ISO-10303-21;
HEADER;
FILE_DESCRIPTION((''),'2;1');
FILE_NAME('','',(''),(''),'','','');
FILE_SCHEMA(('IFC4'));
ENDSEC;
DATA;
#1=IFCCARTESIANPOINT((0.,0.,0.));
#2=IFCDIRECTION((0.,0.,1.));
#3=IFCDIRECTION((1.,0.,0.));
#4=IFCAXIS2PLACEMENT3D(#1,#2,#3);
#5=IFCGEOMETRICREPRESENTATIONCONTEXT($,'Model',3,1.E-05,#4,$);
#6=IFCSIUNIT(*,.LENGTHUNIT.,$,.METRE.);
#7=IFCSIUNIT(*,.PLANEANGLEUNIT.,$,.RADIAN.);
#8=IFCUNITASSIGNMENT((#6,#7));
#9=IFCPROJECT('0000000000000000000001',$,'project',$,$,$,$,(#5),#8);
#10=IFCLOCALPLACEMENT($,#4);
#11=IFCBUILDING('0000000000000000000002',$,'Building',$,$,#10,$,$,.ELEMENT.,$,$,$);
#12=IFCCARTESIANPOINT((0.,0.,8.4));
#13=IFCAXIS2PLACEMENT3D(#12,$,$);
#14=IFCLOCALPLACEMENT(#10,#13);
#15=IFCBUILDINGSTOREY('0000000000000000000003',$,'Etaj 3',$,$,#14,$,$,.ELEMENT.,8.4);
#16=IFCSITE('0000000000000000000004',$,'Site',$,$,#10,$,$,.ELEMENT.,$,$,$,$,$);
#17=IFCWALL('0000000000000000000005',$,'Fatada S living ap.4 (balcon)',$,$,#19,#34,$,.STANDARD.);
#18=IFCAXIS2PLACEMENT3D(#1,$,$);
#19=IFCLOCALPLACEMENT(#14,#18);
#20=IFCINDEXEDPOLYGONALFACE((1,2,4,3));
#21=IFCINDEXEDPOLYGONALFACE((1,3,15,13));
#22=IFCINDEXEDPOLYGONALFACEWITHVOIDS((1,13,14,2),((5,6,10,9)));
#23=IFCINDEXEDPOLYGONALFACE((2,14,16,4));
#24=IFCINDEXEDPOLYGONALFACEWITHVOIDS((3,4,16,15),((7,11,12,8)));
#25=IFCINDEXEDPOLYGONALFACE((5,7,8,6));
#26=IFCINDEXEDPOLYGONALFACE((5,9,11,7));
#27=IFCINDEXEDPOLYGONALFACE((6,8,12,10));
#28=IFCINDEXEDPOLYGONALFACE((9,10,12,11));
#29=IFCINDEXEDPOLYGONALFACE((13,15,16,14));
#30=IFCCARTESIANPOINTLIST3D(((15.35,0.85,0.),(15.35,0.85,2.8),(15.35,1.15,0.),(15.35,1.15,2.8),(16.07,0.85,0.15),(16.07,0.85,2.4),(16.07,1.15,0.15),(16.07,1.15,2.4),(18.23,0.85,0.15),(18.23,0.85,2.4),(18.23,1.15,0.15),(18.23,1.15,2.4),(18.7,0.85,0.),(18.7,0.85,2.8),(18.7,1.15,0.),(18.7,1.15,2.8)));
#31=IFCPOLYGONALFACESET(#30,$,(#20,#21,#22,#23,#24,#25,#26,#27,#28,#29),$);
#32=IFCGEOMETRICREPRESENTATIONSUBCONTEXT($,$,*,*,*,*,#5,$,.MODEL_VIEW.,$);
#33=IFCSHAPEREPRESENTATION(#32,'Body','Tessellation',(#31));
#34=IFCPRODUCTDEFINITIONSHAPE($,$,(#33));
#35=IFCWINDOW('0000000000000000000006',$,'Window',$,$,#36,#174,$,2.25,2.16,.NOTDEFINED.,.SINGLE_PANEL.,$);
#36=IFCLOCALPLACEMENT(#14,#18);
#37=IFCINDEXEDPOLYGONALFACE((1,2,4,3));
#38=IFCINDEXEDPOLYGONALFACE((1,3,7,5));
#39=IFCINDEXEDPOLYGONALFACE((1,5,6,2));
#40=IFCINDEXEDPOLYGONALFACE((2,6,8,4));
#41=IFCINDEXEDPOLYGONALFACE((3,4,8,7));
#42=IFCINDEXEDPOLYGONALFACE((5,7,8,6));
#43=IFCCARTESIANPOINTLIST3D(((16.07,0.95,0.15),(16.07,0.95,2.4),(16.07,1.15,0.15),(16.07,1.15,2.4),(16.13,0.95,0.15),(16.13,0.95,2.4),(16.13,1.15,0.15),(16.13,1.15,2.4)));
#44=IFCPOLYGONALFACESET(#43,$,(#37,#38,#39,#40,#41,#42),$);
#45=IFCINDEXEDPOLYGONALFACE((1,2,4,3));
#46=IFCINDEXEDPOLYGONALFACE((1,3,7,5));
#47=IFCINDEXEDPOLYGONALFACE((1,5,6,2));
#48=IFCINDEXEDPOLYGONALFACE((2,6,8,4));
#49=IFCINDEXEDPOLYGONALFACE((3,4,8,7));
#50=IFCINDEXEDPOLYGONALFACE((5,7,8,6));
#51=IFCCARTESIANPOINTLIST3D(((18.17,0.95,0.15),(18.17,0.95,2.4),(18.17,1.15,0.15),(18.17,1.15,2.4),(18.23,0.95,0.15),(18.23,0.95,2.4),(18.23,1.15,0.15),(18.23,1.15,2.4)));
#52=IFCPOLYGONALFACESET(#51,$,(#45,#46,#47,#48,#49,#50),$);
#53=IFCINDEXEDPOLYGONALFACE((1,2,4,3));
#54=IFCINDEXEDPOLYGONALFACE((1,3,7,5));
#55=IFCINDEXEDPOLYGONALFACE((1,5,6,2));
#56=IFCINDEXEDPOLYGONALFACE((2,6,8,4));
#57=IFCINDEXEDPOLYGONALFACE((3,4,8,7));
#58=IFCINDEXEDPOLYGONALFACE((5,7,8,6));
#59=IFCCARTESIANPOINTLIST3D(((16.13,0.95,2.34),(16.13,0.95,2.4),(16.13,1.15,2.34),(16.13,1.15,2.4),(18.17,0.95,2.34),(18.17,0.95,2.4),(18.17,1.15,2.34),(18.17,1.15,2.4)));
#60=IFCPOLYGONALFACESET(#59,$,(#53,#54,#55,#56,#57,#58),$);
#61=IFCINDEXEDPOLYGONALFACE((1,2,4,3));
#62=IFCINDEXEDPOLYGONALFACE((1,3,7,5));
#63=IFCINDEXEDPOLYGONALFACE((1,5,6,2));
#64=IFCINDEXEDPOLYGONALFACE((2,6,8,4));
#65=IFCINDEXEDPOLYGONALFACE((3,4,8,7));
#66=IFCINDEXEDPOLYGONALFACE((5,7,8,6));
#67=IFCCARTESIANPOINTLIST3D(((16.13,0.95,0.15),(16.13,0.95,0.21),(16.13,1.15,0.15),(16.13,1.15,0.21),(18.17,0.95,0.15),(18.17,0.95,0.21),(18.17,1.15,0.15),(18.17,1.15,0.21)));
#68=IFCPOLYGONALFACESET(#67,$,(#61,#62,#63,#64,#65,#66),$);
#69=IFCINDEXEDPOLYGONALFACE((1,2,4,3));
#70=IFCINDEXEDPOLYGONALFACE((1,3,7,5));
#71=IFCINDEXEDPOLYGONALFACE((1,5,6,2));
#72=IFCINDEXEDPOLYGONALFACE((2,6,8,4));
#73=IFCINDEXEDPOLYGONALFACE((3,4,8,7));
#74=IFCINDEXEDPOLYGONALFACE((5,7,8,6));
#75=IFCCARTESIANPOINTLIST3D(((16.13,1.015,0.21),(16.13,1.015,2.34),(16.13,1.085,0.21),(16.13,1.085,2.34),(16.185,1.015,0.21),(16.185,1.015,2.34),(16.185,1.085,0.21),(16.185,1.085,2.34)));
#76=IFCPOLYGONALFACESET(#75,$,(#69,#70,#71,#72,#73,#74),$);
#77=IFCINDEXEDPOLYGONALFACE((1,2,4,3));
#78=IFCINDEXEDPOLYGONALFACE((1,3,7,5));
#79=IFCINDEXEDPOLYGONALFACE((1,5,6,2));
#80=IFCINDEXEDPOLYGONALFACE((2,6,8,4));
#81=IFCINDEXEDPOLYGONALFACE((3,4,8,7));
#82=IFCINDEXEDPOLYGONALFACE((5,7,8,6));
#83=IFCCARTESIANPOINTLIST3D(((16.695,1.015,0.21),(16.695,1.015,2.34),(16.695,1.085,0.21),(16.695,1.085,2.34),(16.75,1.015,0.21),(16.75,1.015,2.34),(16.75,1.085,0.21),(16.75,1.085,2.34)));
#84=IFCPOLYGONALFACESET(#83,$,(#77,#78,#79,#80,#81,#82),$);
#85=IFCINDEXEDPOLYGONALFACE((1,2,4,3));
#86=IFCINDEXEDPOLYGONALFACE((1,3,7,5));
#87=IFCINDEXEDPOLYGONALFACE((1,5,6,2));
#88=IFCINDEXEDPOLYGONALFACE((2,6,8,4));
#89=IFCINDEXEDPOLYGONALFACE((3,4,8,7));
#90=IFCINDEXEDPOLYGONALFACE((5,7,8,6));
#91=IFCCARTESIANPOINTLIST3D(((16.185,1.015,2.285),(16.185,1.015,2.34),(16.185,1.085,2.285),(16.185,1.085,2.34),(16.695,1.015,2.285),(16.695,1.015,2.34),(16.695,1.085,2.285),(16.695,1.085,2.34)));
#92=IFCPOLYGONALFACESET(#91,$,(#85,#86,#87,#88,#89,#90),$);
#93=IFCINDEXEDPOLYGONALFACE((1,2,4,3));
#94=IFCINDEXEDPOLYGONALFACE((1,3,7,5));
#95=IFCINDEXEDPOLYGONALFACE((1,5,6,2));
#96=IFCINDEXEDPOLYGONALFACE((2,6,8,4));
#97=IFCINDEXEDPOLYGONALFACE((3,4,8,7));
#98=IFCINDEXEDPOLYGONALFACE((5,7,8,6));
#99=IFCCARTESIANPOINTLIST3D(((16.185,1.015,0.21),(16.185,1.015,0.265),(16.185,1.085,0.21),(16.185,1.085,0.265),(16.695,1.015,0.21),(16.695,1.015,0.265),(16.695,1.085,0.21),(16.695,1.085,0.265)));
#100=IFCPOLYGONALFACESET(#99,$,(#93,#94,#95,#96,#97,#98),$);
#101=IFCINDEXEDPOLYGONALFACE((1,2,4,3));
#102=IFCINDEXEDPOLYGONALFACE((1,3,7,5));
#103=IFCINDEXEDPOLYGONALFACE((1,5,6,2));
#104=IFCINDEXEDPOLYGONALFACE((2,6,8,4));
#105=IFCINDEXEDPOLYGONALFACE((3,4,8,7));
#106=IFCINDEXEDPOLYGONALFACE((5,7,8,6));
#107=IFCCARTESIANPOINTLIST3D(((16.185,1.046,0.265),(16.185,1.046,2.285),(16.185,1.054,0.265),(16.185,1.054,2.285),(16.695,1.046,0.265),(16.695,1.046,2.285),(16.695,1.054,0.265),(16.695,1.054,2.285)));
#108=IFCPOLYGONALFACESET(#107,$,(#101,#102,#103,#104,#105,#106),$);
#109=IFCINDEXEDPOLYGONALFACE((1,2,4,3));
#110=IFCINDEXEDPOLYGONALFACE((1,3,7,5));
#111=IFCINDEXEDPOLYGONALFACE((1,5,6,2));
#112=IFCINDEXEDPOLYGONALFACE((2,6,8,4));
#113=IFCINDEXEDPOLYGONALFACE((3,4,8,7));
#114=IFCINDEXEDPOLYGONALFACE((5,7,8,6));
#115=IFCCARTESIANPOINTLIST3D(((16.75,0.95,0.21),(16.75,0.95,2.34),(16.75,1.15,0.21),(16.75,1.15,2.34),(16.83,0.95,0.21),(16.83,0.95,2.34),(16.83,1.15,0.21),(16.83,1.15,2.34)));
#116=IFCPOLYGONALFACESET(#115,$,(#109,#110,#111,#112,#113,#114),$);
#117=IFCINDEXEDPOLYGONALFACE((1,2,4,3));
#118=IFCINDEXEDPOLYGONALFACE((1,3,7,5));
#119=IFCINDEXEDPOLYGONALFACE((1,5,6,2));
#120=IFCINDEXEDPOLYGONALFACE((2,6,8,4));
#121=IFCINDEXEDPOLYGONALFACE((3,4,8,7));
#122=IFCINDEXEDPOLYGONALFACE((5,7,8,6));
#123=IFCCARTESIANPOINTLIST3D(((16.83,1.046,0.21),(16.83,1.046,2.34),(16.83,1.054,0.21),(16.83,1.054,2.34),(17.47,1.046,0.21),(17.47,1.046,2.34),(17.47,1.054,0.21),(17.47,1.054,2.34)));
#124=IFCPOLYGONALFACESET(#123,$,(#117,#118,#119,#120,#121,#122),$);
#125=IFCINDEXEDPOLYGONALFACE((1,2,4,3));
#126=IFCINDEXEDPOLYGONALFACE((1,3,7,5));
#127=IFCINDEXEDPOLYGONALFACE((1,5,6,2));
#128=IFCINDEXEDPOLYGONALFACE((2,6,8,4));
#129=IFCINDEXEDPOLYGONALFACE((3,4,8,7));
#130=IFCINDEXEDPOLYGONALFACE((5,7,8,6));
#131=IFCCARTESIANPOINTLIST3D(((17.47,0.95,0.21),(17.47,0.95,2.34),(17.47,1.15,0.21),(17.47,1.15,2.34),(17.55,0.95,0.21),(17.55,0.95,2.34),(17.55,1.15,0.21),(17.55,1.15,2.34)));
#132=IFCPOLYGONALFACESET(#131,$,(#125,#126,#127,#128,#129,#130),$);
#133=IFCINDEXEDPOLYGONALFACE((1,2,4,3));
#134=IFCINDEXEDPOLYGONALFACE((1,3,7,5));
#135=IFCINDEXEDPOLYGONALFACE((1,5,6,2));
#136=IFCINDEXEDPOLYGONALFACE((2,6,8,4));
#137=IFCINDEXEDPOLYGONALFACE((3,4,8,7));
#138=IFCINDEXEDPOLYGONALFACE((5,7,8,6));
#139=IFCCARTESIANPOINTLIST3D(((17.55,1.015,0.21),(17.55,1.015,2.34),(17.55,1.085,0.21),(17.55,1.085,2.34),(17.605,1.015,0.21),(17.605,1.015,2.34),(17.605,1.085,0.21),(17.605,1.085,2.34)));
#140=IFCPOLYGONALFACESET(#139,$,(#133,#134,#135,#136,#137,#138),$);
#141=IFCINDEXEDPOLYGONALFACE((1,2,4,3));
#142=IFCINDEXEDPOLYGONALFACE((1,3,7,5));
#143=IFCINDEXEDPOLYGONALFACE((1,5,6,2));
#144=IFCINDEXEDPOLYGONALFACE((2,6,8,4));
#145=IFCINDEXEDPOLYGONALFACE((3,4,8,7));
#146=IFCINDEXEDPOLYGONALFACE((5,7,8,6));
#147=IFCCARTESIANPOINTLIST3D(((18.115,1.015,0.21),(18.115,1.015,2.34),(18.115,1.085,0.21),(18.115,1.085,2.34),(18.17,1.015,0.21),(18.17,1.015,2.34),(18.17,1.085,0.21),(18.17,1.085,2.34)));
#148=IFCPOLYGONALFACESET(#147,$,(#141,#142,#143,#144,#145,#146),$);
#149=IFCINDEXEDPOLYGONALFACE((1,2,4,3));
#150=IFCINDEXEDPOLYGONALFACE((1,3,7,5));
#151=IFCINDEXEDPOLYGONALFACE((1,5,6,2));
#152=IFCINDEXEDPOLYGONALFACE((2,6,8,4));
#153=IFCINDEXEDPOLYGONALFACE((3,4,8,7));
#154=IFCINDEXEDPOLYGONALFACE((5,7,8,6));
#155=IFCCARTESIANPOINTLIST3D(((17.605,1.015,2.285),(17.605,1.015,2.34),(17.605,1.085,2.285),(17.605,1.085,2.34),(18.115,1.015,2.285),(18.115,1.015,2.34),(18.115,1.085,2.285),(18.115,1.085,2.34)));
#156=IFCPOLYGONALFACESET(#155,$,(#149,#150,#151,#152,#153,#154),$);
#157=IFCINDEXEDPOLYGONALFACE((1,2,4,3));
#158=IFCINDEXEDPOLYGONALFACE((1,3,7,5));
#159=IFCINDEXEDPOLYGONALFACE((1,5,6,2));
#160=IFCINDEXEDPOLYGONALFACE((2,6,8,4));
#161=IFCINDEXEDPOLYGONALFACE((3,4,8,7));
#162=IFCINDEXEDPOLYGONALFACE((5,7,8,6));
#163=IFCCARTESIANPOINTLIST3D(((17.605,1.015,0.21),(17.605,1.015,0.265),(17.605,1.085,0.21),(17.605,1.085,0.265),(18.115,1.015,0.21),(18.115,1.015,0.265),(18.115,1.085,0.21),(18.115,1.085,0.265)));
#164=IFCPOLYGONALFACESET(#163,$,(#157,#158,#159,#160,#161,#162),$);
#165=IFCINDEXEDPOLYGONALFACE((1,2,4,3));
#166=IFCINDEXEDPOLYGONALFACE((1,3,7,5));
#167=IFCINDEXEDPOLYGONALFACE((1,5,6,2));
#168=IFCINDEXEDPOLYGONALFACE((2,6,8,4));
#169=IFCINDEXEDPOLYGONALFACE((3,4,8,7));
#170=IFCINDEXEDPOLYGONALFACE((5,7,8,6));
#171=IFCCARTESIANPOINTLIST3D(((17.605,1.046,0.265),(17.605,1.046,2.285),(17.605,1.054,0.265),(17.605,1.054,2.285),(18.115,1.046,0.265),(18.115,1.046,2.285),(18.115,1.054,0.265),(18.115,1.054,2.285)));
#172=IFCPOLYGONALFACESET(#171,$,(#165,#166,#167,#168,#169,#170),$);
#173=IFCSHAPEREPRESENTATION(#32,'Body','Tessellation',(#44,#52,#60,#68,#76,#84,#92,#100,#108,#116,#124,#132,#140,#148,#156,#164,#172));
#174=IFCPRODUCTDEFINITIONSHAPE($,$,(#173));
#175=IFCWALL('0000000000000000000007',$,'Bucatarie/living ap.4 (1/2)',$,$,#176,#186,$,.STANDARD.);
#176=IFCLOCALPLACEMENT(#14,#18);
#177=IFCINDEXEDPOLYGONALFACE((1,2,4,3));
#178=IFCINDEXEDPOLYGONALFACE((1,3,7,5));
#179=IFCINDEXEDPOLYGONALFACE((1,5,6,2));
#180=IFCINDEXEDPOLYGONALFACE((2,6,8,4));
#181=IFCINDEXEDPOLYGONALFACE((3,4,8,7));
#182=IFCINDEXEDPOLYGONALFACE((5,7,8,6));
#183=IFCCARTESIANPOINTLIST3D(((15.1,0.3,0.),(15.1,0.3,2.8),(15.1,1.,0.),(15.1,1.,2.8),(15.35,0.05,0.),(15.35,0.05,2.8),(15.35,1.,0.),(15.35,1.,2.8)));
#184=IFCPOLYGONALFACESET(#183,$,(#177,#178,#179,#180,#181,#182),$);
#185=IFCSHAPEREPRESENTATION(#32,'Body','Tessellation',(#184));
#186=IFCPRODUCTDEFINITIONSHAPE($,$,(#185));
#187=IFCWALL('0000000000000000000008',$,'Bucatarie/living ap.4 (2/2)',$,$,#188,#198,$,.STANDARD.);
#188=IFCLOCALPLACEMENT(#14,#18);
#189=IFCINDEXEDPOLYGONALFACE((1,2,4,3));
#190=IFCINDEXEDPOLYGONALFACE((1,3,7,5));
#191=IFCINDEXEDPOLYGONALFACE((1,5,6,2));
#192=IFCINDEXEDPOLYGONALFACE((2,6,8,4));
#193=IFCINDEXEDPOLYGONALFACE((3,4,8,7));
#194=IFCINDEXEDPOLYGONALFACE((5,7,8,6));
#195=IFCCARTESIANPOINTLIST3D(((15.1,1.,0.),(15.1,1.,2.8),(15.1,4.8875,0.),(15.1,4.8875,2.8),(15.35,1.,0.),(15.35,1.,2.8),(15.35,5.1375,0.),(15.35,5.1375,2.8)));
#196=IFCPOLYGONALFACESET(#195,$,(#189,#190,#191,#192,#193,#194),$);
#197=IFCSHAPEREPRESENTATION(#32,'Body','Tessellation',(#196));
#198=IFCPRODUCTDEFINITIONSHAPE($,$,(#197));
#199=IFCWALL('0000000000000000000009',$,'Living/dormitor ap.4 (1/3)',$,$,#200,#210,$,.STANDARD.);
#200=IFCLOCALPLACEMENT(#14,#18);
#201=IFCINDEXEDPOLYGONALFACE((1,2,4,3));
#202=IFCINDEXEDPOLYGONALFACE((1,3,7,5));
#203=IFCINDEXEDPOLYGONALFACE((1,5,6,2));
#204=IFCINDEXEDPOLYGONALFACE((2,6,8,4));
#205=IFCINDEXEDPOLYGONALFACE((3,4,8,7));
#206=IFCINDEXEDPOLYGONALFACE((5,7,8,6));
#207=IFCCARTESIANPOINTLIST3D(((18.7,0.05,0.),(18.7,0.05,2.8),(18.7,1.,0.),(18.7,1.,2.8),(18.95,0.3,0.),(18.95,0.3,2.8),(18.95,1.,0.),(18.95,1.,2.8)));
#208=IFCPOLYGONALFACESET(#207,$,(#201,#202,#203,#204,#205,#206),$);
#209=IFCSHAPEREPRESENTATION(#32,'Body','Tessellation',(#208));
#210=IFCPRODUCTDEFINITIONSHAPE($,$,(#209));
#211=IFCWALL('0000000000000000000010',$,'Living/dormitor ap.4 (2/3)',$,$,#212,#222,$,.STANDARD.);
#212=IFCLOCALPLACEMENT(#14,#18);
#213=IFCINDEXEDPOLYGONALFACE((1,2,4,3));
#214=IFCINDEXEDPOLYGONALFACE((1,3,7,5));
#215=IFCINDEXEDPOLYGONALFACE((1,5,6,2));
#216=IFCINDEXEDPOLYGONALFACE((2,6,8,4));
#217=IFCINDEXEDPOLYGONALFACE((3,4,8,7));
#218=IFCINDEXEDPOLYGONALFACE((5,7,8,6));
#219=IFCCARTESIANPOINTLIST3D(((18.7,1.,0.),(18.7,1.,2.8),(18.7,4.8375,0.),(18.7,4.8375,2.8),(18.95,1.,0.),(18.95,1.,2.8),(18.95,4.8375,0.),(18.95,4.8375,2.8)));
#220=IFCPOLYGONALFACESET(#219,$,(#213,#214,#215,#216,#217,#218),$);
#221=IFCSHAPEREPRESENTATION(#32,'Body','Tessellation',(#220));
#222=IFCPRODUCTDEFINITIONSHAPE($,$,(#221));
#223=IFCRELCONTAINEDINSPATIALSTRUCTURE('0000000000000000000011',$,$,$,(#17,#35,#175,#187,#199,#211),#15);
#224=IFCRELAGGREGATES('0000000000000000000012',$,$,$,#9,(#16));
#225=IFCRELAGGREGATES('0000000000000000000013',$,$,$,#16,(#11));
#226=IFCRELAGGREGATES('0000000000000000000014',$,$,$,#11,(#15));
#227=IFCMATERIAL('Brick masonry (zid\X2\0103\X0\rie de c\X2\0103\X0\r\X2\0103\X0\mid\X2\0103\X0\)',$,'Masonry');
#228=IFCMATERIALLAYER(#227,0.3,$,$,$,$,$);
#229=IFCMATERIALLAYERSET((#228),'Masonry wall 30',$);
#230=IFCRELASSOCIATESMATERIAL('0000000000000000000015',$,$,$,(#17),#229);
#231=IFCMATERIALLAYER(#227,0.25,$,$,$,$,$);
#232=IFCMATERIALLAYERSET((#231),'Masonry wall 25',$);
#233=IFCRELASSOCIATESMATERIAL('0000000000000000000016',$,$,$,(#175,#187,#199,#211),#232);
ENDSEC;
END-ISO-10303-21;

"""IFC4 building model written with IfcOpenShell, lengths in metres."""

from ifc_helpers import new_model, si_unit, frame, frame_2d, origin, origin_with_axes, origin_2d, place, context, subcontext, project, spatial, rectangle, extrude, clip, halfspace, material, layer, layer_set, layer_usage, element, fill, save


model = new_model("IFC4")

# Units and contexts
model_context = context("Model", 3, precision=1e-05, world=origin_with_axes())
sub_context = subcontext(model_context, None, None, "MODEL_VIEW")
ifc_project = project(units=[si_unit("LENGTHUNIT", "METRE"), si_unit("PLANEANGLEUNIT", "RADIAN")], contexts=[model_context])

# Site, building, storey
placement = place(None, origin_with_axes())
site = spatial("IfcSite", under=ifc_project, at=placement, Name="Site", CompositionType="ELEMENT")
building = spatial("IfcBuilding", under=site, at=placement, Name="Building", CompositionType="ELEMENT")
storey_placement = place(placement, frame((0.0, 0.0, 8.4)))
storey = spatial("IfcBuildingStorey", under=building, at=storey_placement, Name="Etaj 3", CompositionType="ELEMENT", Elevation=8.4)

# Shared definitions
ifc_material_1 = material(Name="Brick masonry (zidărie de cărămidă)", Category="Masonry")

# Wall, opening, window
ifc_layer_1 = layer(ifc_material_1, 0.3)
ifc_layer_set_1 = layer_set([ifc_layer_1], Name="Masonry wall 30")
ifc_layer_usage_1 = layer_usage(ifc_layer_set_1, "AXIS2", "POSITIVE", -0.15)
wall_1_placement = place(storey_placement, frame((15.35, 1.0, 0.0), x_axis=(1.0, 0.0, 0.0)))
wall_1 = element("IfcWall", 1, at=wall_1_placement, inside=storey, material=ifc_layer_usage_1, Name="Fatada S living ap.4 (balcon)", PredefinedType="STANDARD", context=sub_context, shape_type="SweptSolid", body=[
    extrude(rectangle(XDim=3.35, YDim=0.3, at=frame_2d((1.675, 0.0))), origin(), (0.0, 0.0, 1.0), 2.8),
])
opening_1_placement = place(wall_1_placement, frame((1.8, 0.2, 0.15), z_axis=(0.0, -1.0, 0.0), x_axis=(1.0, 0.0, 0.0)))
opening_1 = element("IfcOpeningElement", 2, at=opening_1_placement, cuts=wall_1, PredefinedType="OPENING", context=sub_context, shape_type="SweptSolid", body=[
    extrude(rectangle(XDim=2.16, YDim=2.25, at=frame_2d((0.0, 1.125))), origin(), (0.0, 0.0, 1.0), 0.4),
])
window_1_placement = place(wall_1_placement, frame((1.8, 0.15, 0.15), z_axis=(0.0, -1.0, 0.0), x_axis=(1.0, 0.0, 0.0)))
window_1 = element("IfcWindow", 3, at=window_1_placement, inside=storey, Name="Window", OverallHeight=2.25, OverallWidth=2.16, PartitioningType="SINGLE_PANEL", PredefinedType="NOTDEFINED", context=sub_context, shape_type="SweptSolid", body=[
    extrude(rectangle(XDim=0.06, YDim=2.25, at=origin_2d()), frame((-1.05, 1.125, 0.0)), (0.0, 0.0, 1.0), 0.2),
    extrude(rectangle(XDim=0.06, YDim=2.25, at=origin_2d()), frame((1.05, 1.125, 0.0)), (0.0, 0.0, 1.0), 0.2),
    extrude(rectangle(XDim=2.04, YDim=0.06, at=origin_2d()), frame((0.0, 2.22, 0.0)), (0.0, 0.0, 1.0), 0.2),
    extrude(rectangle(XDim=2.04, YDim=0.06, at=origin_2d()), frame((0.0, 0.03, 0.0)), (0.0, 0.0, 1.0), 0.2),
    extrude(rectangle(XDim=0.055, YDim=2.13, at=origin_2d()), frame((-0.9925, 1.125, 0.065)), (0.0, 0.0, 1.0), 0.07),
    extrude(rectangle(XDim=0.055, YDim=2.13, at=origin_2d()), frame((-0.4275, 1.125, 0.065)), (0.0, 0.0, 1.0), 0.07),
    extrude(rectangle(XDim=0.51, YDim=0.055, at=origin_2d()), frame((-0.71, 2.1625, 0.065)), (0.0, 0.0, 1.0), 0.07),
    extrude(rectangle(XDim=0.51, YDim=0.055, at=origin_2d()), frame((-0.71, 0.0875, 0.065)), (0.0, 0.0, 1.0), 0.07),
    extrude(rectangle(XDim=0.51, YDim=2.02, at=origin_2d()), frame((-0.71, 1.125, 0.096)), (0.0, 0.0, 1.0), 0.008),
    extrude(rectangle(XDim=0.08, YDim=2.13, at=origin_2d()), frame((-0.36, 1.125, 0.0)), (0.0, 0.0, 1.0), 0.2),
    extrude(rectangle(XDim=0.64, YDim=2.13, at=origin_2d()), frame((0.0, 1.125, 0.096)), (0.0, 0.0, 1.0), 0.008),
    extrude(rectangle(XDim=0.08, YDim=2.13, at=origin_2d()), frame((0.36, 1.125, 0.0)), (0.0, 0.0, 1.0), 0.2),
    extrude(rectangle(XDim=0.055, YDim=2.13, at=origin_2d()), frame((0.4275, 1.125, 0.065)), (0.0, 0.0, 1.0), 0.07),
    extrude(rectangle(XDim=0.055, YDim=2.13, at=origin_2d()), frame((0.9925, 1.125, 0.065)), (0.0, 0.0, 1.0), 0.07),
    extrude(rectangle(XDim=0.51, YDim=0.055, at=origin_2d()), frame((0.71, 2.1625, 0.065)), (0.0, 0.0, 1.0), 0.07),
    extrude(rectangle(XDim=0.51, YDim=0.055, at=origin_2d()), frame((0.71, 0.0875, 0.065)), (0.0, 0.0, 1.0), 0.07),
    extrude(rectangle(XDim=0.51, YDim=2.02, at=origin_2d()), frame((0.71, 1.125, 0.096)), (0.0, 0.0, 1.0), 0.008),
])
fill(opening_1, window_1)

# Walls
ifc_layer_2 = layer(ifc_material_1, 0.25)
ifc_layer_set_2 = layer_set([ifc_layer_2], Name="Masonry wall 25")
ifc_layer_usage_2 = layer_usage(ifc_layer_set_2, "AXIS2", "POSITIVE", -0.125)
wall_2_placement = place(storey_placement, frame((15.225, 0.05, 0.0), x_axis=(0.0, 1.0, 0.0)))
element("IfcWall", 4, at=wall_2_placement, inside=storey, material=ifc_layer_usage_2, Name="Bucatarie/living ap.4 (1/2)", PredefinedType="STANDARD", context=sub_context, shape_type="CSG", body=[
    clip(extrude(rectangle(XDim=0.95, YDim=0.25, at=frame_2d((0.475, 0.0))), origin(), (0.0, 0.0, 1.0), 2.8), halfspace(frame((0.125, 0.0, 0.0), z_axis=(-0.707107, 0.707107, 0.0)), False)),
])
wall_3_placement = place(storey_placement, frame((15.225, 1.0, 0.0), x_axis=(0.0, 1.0, 0.0)))
element("IfcWall", 5, at=wall_3_placement, inside=storey, material=ifc_layer_usage_2, Name="Bucatarie/living ap.4 (2/2)", PredefinedType="STANDARD", context=sub_context, shape_type="CSG", body=[
    clip(extrude(rectangle(XDim=4.1375, YDim=0.25, at=frame_2d((2.0688, 0.0))), origin(), (0.0, 0.0, 1.0), 2.8), halfspace(frame((4.0125, 0.0, 0.0), z_axis=(0.707107, 0.707107, 0.0)), False)),
])
wall_4_placement = place(storey_placement, frame((18.825, 0.05, 0.0), x_axis=(0.0, 1.0, 0.0)))
element("IfcWall", 6, at=wall_4_placement, inside=storey, material=ifc_layer_usage_2, Name="Living/dormitor ap.4 (1/3)", PredefinedType="STANDARD", context=sub_context, shape_type="CSG", body=[
    clip(extrude(rectangle(XDim=0.95, YDim=0.25, at=frame_2d((0.475, 0.0))), origin(), (0.0, 0.0, 1.0), 2.8), halfspace(frame((0.125, 0.0, 0.0), z_axis=(-0.707107, -0.707107, 0.0)), False)),
])
wall_5_placement = place(storey_placement, frame((18.825, 1.0, 0.0), x_axis=(0.0, 1.0, 0.0)))
element("IfcWall", 7, at=wall_5_placement, inside=storey, material=ifc_layer_usage_2, Name="Living/dormitor ap.4 (2/3)", PredefinedType="STANDARD", context=sub_context, shape_type="SweptSolid", body=[
    extrude(rectangle(XDim=3.8375, YDim=0.25, at=frame_2d((1.9188, 0.0))), origin(), (0.0, 0.0, 1.0), 2.8),
])

save(model, "model.ifc")
